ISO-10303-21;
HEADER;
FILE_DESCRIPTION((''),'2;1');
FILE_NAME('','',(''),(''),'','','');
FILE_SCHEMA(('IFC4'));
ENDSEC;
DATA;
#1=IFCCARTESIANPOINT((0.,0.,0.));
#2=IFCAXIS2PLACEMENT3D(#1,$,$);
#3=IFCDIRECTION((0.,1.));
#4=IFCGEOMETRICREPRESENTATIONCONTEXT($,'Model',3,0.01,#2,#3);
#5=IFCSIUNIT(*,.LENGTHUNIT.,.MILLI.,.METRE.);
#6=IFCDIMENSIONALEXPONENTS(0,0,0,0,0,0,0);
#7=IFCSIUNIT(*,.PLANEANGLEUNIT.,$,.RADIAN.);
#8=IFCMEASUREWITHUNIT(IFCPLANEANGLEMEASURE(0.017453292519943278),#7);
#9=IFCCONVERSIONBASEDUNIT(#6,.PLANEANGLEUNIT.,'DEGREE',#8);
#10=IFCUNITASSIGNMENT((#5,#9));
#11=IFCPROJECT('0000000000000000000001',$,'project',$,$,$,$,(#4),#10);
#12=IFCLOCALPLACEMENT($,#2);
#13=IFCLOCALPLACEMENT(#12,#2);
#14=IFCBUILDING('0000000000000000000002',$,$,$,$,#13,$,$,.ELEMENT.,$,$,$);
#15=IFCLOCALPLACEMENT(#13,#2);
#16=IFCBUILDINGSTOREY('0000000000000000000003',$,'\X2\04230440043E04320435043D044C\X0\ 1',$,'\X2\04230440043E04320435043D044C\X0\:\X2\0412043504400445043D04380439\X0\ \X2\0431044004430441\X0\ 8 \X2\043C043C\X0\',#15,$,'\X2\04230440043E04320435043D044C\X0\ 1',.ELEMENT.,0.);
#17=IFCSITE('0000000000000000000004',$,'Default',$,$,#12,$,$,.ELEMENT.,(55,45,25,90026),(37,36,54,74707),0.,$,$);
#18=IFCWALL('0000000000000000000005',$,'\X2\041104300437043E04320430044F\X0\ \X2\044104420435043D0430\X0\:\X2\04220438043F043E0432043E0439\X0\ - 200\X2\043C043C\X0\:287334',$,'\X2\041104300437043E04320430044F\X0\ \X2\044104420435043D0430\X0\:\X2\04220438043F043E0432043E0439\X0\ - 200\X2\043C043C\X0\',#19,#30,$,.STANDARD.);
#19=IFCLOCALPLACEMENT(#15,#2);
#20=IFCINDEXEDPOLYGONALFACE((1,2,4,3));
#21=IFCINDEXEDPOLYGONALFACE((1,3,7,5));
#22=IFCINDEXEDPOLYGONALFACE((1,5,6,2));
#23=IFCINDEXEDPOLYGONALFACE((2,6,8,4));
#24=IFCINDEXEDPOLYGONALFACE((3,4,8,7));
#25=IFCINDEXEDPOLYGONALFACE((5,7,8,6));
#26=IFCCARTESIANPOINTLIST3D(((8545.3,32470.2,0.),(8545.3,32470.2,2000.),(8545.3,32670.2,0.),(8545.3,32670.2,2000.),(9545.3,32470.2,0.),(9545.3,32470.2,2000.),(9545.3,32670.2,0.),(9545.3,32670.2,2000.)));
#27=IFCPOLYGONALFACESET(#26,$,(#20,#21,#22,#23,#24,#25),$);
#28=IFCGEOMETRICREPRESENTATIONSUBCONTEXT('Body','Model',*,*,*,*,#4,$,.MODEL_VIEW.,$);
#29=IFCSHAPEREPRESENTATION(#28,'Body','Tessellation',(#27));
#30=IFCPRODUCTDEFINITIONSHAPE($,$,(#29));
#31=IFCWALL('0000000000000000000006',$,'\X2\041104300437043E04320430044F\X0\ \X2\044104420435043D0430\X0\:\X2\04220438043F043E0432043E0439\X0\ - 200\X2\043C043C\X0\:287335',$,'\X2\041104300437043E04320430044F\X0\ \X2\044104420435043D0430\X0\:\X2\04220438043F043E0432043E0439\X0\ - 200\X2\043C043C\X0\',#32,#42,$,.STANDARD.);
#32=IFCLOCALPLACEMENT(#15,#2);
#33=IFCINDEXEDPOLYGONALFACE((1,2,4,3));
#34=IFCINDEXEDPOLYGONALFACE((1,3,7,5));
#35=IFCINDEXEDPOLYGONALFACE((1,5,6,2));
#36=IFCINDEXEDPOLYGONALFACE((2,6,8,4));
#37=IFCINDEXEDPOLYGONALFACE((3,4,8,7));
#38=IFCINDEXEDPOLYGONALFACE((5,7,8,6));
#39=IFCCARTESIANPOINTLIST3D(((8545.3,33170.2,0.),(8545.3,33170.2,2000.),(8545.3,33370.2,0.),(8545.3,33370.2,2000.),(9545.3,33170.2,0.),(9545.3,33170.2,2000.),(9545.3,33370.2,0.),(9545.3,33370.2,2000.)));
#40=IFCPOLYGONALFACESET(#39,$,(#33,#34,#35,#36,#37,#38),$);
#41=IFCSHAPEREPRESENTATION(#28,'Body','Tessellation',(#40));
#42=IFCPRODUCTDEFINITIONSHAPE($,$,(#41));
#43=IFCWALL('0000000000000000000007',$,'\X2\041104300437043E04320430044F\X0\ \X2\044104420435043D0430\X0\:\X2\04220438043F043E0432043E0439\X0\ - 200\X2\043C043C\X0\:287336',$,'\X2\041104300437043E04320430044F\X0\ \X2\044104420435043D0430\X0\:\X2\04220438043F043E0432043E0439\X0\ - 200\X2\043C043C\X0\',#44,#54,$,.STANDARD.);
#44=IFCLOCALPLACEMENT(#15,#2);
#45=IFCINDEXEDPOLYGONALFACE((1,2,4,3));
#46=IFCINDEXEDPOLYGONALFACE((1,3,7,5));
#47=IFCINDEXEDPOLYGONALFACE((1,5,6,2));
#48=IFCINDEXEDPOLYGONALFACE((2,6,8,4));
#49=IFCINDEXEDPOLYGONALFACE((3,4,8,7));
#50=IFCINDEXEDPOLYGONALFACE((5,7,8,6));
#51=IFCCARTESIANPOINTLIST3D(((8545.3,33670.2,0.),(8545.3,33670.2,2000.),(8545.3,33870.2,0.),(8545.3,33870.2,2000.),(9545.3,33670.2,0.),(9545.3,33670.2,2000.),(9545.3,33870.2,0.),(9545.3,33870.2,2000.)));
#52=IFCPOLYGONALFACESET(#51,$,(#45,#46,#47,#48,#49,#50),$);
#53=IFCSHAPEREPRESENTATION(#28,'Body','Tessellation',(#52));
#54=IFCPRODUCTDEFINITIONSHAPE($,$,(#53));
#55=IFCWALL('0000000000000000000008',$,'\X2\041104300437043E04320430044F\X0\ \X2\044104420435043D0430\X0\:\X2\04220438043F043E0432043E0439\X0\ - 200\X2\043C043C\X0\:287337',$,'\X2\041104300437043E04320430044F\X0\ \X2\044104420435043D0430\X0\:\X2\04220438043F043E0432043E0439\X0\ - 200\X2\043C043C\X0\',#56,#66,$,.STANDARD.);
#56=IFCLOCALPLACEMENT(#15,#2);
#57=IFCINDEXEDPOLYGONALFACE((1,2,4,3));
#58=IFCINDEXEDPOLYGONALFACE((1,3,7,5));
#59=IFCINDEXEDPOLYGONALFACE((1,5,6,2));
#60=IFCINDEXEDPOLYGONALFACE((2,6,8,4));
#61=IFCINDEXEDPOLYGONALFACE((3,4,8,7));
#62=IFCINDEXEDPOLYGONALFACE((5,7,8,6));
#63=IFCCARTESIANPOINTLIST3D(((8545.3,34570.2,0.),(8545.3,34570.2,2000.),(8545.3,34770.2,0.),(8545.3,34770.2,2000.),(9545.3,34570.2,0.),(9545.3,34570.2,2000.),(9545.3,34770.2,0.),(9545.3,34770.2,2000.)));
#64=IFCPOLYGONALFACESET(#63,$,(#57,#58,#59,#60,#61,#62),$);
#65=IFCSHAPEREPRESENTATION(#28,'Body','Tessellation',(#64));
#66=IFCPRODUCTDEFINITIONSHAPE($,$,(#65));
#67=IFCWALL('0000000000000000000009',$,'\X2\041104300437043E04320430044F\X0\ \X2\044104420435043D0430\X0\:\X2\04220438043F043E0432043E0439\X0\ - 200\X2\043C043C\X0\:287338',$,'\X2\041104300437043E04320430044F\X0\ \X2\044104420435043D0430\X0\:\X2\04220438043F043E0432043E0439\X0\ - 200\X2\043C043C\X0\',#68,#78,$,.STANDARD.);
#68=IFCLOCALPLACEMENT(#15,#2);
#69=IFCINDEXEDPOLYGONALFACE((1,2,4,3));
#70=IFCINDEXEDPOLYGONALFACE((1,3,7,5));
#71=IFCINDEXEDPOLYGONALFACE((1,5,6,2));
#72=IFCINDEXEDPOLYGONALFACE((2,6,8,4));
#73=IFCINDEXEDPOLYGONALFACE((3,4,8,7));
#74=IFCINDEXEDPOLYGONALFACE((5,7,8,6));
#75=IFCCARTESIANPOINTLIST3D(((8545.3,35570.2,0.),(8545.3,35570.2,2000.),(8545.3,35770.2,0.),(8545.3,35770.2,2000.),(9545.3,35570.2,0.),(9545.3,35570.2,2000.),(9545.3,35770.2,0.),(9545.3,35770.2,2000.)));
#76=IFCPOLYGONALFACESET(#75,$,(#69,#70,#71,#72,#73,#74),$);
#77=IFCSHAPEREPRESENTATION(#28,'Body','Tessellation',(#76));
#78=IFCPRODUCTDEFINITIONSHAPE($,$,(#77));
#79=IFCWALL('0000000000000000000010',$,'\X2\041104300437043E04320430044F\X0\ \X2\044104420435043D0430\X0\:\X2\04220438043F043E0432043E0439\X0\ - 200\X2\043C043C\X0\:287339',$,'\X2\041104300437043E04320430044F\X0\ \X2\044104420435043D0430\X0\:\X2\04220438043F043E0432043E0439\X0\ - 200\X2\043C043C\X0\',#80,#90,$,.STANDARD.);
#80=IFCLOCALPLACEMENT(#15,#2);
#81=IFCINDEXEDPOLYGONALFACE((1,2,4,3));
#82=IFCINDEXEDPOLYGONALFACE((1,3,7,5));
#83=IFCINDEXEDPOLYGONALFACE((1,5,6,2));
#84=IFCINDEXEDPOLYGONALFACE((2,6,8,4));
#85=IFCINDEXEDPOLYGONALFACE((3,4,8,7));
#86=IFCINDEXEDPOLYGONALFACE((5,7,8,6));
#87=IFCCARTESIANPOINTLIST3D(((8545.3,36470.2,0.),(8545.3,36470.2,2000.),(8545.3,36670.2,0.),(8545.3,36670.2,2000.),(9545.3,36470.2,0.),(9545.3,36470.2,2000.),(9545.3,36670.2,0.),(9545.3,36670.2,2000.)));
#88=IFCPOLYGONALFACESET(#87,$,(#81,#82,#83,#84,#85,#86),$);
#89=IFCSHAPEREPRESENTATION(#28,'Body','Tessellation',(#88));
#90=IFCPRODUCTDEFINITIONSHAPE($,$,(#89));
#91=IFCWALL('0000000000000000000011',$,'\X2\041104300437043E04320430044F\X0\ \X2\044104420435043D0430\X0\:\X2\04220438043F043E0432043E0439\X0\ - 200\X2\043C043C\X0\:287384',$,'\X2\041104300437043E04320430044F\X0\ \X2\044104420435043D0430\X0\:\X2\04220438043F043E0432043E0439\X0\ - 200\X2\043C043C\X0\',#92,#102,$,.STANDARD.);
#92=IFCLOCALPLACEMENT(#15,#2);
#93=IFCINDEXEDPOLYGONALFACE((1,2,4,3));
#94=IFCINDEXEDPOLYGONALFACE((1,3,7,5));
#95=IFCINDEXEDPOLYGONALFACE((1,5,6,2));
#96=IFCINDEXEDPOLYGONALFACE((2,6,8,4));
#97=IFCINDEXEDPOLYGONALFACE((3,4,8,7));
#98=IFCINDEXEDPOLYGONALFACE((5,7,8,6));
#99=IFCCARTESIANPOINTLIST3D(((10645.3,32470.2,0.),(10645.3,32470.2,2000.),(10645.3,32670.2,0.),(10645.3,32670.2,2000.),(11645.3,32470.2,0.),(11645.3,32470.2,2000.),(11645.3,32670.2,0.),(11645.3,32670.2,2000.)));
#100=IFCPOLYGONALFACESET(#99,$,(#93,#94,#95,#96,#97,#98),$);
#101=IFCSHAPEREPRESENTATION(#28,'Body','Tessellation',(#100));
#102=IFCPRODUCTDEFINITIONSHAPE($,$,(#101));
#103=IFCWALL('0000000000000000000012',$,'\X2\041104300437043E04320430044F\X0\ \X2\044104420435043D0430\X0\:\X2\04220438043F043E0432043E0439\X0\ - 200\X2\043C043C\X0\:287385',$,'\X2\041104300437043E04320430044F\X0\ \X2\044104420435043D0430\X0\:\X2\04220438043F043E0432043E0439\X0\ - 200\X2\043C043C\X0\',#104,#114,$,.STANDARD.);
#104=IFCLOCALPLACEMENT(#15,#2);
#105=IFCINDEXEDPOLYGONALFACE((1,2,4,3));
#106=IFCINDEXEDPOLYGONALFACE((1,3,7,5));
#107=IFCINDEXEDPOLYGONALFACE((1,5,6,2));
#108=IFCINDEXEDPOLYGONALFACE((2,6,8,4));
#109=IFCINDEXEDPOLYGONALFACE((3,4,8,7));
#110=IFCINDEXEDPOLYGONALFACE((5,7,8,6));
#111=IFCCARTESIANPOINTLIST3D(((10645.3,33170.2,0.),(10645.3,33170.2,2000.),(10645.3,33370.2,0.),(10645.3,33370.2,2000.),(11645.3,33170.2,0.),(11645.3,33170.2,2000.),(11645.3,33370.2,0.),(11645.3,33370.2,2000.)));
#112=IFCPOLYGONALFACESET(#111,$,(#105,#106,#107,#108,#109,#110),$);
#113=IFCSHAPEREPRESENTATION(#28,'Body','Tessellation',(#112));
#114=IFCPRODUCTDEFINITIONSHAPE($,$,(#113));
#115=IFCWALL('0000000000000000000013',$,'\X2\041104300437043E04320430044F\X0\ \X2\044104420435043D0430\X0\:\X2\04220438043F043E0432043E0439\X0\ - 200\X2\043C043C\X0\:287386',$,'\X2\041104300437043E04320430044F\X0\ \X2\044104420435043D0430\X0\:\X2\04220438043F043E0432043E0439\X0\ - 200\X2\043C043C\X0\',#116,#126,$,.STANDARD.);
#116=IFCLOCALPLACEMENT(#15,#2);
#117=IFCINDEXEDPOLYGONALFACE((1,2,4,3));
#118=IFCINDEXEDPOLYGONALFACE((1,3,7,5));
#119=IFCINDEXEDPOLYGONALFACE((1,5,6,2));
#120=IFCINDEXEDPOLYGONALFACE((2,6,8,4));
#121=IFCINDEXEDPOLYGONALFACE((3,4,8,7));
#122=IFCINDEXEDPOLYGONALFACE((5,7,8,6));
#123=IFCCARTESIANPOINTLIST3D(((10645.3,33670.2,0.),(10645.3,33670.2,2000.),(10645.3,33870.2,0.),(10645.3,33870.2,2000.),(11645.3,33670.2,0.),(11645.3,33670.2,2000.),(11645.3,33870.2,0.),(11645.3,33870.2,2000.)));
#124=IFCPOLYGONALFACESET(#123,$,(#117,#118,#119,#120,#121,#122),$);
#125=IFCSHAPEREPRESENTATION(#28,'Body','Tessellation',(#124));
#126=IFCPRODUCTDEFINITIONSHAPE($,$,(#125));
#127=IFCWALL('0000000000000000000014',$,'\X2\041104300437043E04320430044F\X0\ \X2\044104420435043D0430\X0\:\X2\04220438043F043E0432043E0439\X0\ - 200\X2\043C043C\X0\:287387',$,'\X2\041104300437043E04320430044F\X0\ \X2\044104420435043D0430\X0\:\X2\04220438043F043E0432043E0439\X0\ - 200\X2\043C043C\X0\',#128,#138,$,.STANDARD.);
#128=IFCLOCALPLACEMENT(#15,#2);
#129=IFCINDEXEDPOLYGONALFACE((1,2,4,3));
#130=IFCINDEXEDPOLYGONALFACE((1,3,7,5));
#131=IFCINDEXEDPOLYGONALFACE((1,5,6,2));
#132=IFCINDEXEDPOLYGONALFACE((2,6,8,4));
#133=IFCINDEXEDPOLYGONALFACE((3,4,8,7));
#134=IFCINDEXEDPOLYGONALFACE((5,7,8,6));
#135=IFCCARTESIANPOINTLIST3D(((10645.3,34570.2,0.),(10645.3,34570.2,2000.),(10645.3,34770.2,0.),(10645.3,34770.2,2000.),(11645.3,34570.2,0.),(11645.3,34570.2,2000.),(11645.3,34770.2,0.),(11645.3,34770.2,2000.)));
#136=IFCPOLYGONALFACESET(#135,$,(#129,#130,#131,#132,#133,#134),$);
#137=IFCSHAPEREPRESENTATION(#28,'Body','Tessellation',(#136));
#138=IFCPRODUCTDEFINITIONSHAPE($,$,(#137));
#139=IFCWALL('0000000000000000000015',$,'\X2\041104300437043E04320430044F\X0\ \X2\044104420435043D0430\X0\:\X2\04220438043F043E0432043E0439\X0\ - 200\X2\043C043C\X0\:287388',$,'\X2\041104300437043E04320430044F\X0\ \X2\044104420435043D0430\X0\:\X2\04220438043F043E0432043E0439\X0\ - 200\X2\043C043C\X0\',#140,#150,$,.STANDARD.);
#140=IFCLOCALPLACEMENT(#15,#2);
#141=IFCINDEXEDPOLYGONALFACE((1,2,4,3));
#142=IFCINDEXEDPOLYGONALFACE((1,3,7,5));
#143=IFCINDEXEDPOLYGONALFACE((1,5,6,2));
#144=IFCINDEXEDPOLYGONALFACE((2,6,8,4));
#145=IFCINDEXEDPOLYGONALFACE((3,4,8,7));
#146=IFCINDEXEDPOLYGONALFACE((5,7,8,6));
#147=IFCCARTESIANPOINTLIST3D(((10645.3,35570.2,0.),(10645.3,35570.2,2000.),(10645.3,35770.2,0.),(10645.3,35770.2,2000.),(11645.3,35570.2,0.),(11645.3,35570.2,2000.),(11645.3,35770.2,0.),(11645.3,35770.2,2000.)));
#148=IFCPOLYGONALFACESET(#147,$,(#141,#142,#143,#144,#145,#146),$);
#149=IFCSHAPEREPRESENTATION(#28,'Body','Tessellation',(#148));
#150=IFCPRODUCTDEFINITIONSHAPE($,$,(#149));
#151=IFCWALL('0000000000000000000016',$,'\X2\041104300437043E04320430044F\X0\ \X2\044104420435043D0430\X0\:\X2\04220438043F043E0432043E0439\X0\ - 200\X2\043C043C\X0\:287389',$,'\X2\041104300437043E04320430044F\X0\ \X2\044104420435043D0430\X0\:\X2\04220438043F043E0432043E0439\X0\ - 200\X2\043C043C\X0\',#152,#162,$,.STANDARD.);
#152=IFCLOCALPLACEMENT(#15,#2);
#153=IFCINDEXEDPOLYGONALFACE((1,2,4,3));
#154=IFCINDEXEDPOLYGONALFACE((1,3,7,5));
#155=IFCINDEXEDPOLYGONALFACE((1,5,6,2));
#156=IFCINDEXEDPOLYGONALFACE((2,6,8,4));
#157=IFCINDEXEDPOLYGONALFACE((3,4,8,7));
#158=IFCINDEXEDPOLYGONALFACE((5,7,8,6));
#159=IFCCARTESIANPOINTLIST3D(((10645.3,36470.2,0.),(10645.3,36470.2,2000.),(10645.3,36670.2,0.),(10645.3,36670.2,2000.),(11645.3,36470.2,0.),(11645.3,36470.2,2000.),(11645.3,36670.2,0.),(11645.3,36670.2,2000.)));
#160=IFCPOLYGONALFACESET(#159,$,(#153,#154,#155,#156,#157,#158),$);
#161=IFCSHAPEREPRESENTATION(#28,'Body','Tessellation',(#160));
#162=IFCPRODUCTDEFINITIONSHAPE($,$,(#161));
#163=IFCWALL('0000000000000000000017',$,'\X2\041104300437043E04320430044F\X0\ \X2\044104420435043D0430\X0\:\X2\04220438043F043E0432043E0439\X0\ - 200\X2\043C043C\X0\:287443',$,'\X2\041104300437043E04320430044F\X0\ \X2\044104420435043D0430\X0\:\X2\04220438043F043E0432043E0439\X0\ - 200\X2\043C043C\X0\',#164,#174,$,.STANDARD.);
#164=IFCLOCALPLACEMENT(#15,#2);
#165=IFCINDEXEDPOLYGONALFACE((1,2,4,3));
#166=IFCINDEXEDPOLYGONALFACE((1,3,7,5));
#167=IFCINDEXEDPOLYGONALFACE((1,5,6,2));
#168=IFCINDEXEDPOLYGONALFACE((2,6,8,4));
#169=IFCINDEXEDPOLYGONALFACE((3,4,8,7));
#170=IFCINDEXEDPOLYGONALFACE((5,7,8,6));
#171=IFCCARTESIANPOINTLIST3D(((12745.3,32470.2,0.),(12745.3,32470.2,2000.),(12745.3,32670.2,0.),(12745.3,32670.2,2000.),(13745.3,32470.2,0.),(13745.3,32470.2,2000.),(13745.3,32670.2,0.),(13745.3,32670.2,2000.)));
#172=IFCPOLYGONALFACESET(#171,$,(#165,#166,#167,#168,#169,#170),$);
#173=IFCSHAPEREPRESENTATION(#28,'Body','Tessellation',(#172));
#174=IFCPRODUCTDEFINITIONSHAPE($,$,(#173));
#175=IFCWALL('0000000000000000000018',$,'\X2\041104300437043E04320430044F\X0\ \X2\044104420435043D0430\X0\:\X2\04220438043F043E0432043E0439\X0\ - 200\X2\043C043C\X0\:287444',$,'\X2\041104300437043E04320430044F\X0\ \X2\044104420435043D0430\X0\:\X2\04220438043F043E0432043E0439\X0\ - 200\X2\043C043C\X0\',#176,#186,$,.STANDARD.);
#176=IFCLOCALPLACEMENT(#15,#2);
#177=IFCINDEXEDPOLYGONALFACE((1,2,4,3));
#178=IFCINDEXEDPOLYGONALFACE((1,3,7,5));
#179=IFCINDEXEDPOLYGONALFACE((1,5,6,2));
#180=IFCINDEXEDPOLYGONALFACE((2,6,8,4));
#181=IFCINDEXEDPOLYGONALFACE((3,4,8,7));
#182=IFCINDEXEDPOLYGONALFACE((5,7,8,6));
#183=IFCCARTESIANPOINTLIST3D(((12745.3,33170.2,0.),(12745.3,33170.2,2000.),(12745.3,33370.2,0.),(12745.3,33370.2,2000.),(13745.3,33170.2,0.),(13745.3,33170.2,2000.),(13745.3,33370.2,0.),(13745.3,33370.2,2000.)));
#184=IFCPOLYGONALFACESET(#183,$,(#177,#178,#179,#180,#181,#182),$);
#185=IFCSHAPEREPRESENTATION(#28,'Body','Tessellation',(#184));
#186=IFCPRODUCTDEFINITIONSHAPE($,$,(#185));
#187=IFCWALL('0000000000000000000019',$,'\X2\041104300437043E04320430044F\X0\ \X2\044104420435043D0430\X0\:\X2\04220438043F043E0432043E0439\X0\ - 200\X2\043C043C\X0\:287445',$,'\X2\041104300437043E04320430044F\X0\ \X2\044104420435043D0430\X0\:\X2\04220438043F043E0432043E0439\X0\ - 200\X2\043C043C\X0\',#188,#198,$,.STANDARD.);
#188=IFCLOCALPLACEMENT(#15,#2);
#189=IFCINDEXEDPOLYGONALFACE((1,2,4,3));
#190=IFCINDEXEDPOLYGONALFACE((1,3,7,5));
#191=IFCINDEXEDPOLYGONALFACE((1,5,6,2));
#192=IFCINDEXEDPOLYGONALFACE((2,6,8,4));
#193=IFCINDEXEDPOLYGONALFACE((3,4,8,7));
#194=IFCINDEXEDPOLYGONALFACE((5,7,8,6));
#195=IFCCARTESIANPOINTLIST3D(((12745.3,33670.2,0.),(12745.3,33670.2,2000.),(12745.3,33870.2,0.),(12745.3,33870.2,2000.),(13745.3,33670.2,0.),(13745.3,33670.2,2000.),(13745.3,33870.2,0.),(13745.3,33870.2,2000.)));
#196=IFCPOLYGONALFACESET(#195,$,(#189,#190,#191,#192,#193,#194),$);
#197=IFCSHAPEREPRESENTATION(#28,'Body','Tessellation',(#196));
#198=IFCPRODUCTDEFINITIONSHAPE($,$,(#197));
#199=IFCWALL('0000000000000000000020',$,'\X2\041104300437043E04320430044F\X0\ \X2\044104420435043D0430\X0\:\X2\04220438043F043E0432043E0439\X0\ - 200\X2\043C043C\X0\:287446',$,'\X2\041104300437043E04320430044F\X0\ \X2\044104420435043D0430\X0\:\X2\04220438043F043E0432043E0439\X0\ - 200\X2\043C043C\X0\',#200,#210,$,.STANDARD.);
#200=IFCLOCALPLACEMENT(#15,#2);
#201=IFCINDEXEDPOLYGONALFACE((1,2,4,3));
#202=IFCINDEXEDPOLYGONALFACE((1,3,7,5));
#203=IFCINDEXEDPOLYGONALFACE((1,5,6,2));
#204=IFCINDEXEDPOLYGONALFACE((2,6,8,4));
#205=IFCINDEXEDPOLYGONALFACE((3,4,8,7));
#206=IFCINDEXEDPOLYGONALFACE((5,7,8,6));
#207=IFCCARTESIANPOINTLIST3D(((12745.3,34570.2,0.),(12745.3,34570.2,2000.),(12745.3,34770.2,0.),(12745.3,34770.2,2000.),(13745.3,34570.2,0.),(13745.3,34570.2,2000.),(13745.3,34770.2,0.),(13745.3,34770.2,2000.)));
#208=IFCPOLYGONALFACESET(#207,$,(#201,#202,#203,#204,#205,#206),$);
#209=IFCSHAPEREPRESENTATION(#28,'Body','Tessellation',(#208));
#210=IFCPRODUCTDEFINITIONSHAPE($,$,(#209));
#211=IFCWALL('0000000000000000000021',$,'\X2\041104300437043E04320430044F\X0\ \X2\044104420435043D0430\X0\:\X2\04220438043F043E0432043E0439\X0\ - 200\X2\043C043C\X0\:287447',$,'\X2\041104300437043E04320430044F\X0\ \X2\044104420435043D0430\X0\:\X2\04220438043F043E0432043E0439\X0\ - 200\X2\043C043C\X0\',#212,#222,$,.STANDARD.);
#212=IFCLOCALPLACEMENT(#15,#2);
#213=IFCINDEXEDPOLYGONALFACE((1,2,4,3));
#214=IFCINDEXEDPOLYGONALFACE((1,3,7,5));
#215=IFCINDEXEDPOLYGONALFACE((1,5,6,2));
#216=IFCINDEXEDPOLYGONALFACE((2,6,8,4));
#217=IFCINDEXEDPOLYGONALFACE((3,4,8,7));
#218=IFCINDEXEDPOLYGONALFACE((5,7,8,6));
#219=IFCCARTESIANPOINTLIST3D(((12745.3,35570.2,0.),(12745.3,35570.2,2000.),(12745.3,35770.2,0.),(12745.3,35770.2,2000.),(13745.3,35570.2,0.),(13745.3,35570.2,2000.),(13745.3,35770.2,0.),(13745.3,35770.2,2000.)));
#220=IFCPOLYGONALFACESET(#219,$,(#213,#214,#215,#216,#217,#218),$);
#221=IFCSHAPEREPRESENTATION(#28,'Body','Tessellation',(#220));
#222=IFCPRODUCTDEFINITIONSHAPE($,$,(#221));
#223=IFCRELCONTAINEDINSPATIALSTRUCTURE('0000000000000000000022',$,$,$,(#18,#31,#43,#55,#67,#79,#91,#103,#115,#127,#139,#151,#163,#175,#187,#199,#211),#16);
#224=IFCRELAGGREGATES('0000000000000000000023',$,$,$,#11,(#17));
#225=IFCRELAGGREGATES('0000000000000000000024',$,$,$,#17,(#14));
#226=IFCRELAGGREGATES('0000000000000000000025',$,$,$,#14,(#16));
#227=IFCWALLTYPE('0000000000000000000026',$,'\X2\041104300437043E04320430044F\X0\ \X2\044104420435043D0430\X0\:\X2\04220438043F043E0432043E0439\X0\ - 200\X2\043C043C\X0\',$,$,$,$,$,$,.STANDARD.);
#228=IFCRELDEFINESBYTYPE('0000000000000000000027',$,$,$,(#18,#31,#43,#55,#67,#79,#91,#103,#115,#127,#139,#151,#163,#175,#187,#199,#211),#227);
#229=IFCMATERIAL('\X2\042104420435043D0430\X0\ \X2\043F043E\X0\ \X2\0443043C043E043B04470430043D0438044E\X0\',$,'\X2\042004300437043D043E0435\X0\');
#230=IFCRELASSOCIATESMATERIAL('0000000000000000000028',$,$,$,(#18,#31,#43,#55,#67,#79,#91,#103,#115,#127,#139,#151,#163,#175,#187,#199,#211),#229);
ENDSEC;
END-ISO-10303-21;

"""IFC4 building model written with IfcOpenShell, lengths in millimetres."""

from ifc_helpers import new_model, entity, si_unit, converted_unit, direction, frame, origin, place, context, subcontext, project, spatial, indexed_curve, outline, extrude, material, type_object, element, save


model = new_model("IFC4")

# Units and contexts
model_context = context("Model", 3, precision=0.01, world=origin(), true_north=direction((0.0, 1.0)))
body_context = subcontext(model_context, "Body", "Model", "MODEL_VIEW")
ifc_project = project(units=[si_unit("LENGTHUNIT", "METRE", prefix="MILLI"), converted_unit("PLANEANGLEUNIT", "DEGREE", entity("IfcPlaneAngleMeasure", 0.017453292519943278), si_unit("PLANEANGLEUNIT", "RADIAN"), dimensions=[0, 0, 0, 0, 0, 0, 0])], contexts=[model_context])

# Site, building, storey
site_placement = place(None, origin())
site = spatial("IfcSite", under=ifc_project, at=site_placement, Name="Default", CompositionType="ELEMENT", RefLatitude=(55, 45, 25, 90026), RefLongitude=(37, 36, 54, 74707), RefElevation=0.0)
building_placement = place(site_placement, origin())
building = spatial("IfcBuilding", under=site, at=building_placement, CompositionType="ELEMENT")
storey_placement = place(building_placement, origin())
storey = spatial("IfcBuildingStorey", under=building, at=storey_placement, Name="Уровень 1", ObjectType="Уровень:Верхний брус 8 мм", LongName="Уровень 1", CompositionType="ELEMENT", Elevation=0.0)

# Walls
ifc_material = material(Name="Стена по умолчанию", Category="Разное")
wall_type = type_object("IfcWallType", Name="Базовая стена:Типовой - 200мм", PredefinedType="STANDARD")
for number, where, name in (
    (1, (8545.3, 32570.2, 0.0), "Базовая стена:Типовой - 200мм:287334"),
    (2, (8545.3, 33270.2, 0.0), "Базовая стена:Типовой - 200мм:287335"),
):
    element("IfcWall", number, at=place(storey_placement, frame(where)), inside=storey, type_object=wall_type, material=ifc_material, Name=name, ObjectType="Базовая стена:Типовой - 200мм", PredefinedType="STANDARD", context=body_context, shape_type="SweptSolid", body=[
        extrude(outline(indexed_curve([(1000.0, 100.0), (0.0, 100.0), (0.0, -100.0), (1000.0, -100.0), (1000.0, 100.0)], self_intersect=False)), origin(), (0.0, 0.0, 1.0), 2000.0),
    ])
for number, where, name in (
    (3, (8545.3, 33770.2, 0.0), "Базовая стена:Типовой - 200мм:287336"),
    (4, (8545.3, 34670.2, 0.0), "Базовая стена:Типовой - 200мм:287337"),
    (5, (8545.3, 35670.2, 0.0), "Базовая стена:Типовой - 200мм:287338"),
):
    element("IfcWall", number, at=place(storey_placement, frame(where)), inside=storey, type_object=wall_type, material=ifc_material, Name=name, ObjectType="Базовая стена:Типовой - 200мм", PredefinedType="STANDARD", context=body_context, shape_type="SweptSolid", body=[
        extrude(outline(indexed_curve([(1000.0, 100.0), (0.0, 100.0), (0.0, -100.0), (1000.0, -100.0), (1000.0, 100.0)], self_intersect=False)), origin(), (0.0, 0.0, 1.0), 2000.0),
    ])
wall_1_placement = place(storey_placement, frame((8545.3, 36570.2, 0.0)))
element("IfcWall", 6, at=wall_1_placement, inside=storey, type_object=wall_type, material=ifc_material, Name="Базовая стена:Типовой - 200мм:287339", ObjectType="Базовая стена:Типовой - 200мм", PredefinedType="STANDARD", context=body_context, shape_type="SweptSolid", body=[
    extrude(outline(indexed_curve([(1000.0, 100.0), (0.0, 100.0), (0.0, -100.0), (1000.0, -100.0), (1000.0, 100.0)], self_intersect=False)), origin(), (0.0, 0.0, 1.0), 2000.0),
])
for number, where, name in (
    (7, (10645.3, 32570.2, 0.0), "Базовая стена:Типовой - 200мм:287384"),
    (8, (10645.3, 33270.2, 0.0), "Базовая стена:Типовой - 200мм:287385"),
):
    element("IfcWall", number, at=place(storey_placement, frame(where)), inside=storey, type_object=wall_type, material=ifc_material, Name=name, ObjectType="Базовая стена:Типовой - 200мм", PredefinedType="STANDARD", context=body_context, shape_type="SweptSolid", body=[
        extrude(outline(indexed_curve([(1000.0, 100.0), (0.0, 100.0), (0.0, -100.0), (1000.0, -100.0), (1000.0, 100.0)], self_intersect=False)), origin(), (0.0, 0.0, 1.0), 2000.0),
    ])
for number, where, name in (
    (9, (10645.3, 33770.2, 0.0), "Базовая стена:Типовой - 200мм:287386"),
    (10, (10645.3, 34670.2, 0.0), "Базовая стена:Типовой - 200мм:287387"),
    (11, (10645.3, 35670.2, 0.0), "Базовая стена:Типовой - 200мм:287388"),
):
    element("IfcWall", number, at=place(storey_placement, frame(where)), inside=storey, type_object=wall_type, material=ifc_material, Name=name, ObjectType="Базовая стена:Типовой - 200мм", PredefinedType="STANDARD", context=body_context, shape_type="SweptSolid", body=[
        extrude(outline(indexed_curve([(1000.0, 100.0), (0.0, 100.0), (0.0, -100.0), (1000.0, -100.0), (1000.0, 100.0)], self_intersect=False)), origin(), (0.0, 0.0, 1.0), 2000.0),
    ])
wall_2_placement = place(storey_placement, frame((10645.3, 36570.2, 0.0)))
element("IfcWall", 12, at=wall_2_placement, inside=storey, type_object=wall_type, material=ifc_material, Name="Базовая стена:Типовой - 200мм:287389", ObjectType="Базовая стена:Типовой - 200мм", PredefinedType="STANDARD", context=body_context, shape_type="SweptSolid", body=[
    extrude(outline(indexed_curve([(1000.0, 100.0), (0.0, 100.0), (0.0, -100.0), (1000.0, -100.0), (1000.0, 100.0)], self_intersect=False)), origin(), (0.0, 0.0, 1.0), 2000.0),
])
for number, where, name in (
    (13, (12745.3, 32570.2, 0.0), "Базовая стена:Типовой - 200мм:287443"),
    (14, (12745.3, 33270.2, 0.0), "Базовая стена:Типовой - 200мм:287444"),
):
    element("IfcWall", number, at=place(storey_placement, frame(where)), inside=storey, type_object=wall_type, material=ifc_material, Name=name, ObjectType="Базовая стена:Типовой - 200мм", PredefinedType="STANDARD", context=body_context, shape_type="SweptSolid", body=[
        extrude(outline(indexed_curve([(1000.0, 100.0), (0.0, 100.0), (0.0, -100.0), (1000.0, -100.0), (1000.0, 100.0)], self_intersect=False)), origin(), (0.0, 0.0, 1.0), 2000.0),
    ])
for number, where, name in (
    (15, (12745.3, 33770.2, 0.0), "Базовая стена:Типовой - 200мм:287445"),
    (16, (12745.3, 34670.2, 0.0), "Базовая стена:Типовой - 200мм:287446"),
    (17, (12745.3, 35670.2, 0.0), "Базовая стена:Типовой - 200мм:287447"),
):
    element("IfcWall", number, at=place(storey_placement, frame(where)), inside=storey, type_object=wall_type, material=ifc_material, Name=name, ObjectType="Базовая стена:Типовой - 200мм", PredefinedType="STANDARD", context=body_context, shape_type="SweptSolid", body=[
        extrude(outline(indexed_curve([(1000.0, 100.0), (0.0, 100.0), (0.0, -100.0), (1000.0, -100.0), (1000.0, 100.0)], self_intersect=False)), origin(), (0.0, 0.0, 1.0), 2000.0),
    ])

save(model, "model.ifc")
